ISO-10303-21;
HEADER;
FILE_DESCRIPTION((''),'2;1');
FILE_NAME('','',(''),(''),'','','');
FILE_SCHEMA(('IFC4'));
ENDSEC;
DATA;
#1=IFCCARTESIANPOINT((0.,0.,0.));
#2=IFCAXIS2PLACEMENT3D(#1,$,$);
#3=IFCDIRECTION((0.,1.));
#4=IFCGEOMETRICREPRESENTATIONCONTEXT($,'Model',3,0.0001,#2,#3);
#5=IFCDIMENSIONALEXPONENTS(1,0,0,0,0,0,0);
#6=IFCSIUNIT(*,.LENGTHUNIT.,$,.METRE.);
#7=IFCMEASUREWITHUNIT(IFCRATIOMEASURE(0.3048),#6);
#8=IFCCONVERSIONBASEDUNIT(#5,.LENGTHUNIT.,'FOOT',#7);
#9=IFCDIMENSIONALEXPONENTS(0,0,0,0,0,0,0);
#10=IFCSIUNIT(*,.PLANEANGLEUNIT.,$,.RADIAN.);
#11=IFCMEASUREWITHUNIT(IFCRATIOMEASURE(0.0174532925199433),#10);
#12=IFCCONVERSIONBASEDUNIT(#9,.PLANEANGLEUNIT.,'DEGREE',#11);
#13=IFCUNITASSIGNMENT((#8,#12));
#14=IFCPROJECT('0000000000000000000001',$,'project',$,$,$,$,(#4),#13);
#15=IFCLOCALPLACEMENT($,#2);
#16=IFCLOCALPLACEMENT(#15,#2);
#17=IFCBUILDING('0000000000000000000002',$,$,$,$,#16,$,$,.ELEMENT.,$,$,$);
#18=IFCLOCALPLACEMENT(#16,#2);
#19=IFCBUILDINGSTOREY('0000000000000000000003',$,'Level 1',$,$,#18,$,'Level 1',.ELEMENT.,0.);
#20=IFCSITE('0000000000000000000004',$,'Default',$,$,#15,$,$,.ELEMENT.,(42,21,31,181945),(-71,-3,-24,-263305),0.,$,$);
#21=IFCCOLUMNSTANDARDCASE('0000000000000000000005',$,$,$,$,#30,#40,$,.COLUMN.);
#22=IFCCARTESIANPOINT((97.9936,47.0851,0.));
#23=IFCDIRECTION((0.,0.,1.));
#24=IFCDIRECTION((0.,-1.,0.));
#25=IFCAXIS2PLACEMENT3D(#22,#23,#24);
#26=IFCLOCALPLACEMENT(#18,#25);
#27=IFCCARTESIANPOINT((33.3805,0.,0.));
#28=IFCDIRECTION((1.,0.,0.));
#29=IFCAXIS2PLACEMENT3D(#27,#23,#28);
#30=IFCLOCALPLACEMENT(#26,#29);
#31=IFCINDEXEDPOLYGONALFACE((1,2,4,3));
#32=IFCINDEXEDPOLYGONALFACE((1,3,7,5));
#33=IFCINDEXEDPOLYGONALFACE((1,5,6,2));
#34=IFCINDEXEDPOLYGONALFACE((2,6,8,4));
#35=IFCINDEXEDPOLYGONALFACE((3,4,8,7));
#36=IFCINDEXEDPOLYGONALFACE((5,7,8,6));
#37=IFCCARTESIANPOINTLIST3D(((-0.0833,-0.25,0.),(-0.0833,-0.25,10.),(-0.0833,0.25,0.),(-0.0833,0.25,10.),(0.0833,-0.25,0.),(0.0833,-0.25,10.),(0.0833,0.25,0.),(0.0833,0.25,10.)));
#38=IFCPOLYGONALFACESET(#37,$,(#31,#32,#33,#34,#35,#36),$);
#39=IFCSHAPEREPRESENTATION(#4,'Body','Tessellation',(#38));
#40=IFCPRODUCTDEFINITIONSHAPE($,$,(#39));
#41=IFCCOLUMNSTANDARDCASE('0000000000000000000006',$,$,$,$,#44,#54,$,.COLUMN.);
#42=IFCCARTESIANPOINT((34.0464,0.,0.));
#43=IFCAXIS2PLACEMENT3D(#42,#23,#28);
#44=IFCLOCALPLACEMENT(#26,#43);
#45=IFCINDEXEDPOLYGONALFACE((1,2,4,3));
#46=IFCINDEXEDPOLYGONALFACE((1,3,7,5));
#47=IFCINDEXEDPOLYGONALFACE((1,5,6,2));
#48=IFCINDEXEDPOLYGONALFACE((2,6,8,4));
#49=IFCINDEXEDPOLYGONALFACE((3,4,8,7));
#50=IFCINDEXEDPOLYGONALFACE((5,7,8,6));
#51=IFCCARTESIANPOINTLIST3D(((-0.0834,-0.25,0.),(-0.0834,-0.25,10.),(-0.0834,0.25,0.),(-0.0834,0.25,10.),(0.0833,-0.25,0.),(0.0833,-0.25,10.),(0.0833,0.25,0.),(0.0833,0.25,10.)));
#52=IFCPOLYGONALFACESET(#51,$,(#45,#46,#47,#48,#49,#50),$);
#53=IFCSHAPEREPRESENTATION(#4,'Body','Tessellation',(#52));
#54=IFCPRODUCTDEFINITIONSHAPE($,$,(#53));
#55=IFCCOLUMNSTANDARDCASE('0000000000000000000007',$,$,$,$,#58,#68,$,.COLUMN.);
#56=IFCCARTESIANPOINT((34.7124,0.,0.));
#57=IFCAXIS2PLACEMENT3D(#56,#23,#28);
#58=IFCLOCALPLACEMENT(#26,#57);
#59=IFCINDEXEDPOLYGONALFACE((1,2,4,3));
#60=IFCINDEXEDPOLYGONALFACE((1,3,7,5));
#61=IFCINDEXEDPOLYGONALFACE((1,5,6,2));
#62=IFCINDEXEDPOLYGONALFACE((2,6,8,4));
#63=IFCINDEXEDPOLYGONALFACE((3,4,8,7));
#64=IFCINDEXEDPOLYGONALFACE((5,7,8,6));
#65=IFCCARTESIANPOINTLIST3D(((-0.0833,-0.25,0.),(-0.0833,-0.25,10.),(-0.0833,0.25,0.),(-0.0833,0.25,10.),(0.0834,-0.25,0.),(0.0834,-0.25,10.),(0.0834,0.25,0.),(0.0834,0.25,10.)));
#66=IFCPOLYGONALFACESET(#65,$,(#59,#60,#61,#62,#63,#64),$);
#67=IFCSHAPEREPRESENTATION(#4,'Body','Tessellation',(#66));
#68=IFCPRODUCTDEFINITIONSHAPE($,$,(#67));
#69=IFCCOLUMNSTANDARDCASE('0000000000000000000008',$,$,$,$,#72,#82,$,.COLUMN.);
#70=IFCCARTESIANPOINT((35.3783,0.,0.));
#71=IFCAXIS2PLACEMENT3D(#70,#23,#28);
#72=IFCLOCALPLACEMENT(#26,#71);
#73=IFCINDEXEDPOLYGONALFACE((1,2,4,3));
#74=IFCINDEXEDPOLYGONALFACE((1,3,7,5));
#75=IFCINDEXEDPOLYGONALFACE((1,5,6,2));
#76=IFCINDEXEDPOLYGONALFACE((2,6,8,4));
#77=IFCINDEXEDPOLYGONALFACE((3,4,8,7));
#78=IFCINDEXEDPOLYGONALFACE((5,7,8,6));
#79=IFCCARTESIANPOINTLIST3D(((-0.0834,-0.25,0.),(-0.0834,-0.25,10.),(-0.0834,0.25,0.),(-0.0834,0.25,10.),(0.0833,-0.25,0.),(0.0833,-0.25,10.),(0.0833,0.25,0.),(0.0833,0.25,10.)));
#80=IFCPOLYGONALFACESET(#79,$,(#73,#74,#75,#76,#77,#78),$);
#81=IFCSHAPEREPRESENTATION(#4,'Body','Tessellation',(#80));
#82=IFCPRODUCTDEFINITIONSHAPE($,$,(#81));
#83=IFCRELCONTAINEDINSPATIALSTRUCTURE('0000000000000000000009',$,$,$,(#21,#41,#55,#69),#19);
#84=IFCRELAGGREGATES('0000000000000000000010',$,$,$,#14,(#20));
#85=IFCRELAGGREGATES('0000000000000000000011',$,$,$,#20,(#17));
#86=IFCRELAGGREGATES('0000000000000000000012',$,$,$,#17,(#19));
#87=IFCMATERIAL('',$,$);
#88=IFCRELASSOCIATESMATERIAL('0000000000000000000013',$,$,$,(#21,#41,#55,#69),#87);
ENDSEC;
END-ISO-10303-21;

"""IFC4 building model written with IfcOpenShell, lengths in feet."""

from ifc_helpers import new_model, entity, si_unit, converted_unit, direction, frame, origin, place, context, project, spatial, rectangle, extrude, material, element, save


model = new_model("IFC4")

# Units and contexts
model_context = context("Model", 3, precision=0.0001, world=origin(), true_north=direction((0.0, 1.0)))
ifc_project = project(units=[converted_unit("LENGTHUNIT", "FOOT", entity("IfcRatioMeasure", 0.3048), si_unit("LENGTHUNIT", "METRE"), dimensions=[1, 0, 0, 0, 0, 0, 0]), converted_unit("PLANEANGLEUNIT", "DEGREE", entity("IfcRatioMeasure", 0.0174532925199433), si_unit("PLANEANGLEUNIT", "RADIAN"), dimensions=[0, 0, 0, 0, 0, 0, 0])], contexts=[model_context])

# Site, building, storey
site_placement = place(None, origin())
site = spatial("IfcSite", under=ifc_project, at=site_placement, Name="Default", CompositionType="ELEMENT", RefLatitude=(42, 21, 31, 181945), RefLongitude=(-71, -3, -24, -263305), RefElevation=0.0)
building_placement = place(site_placement, origin())
building = spatial("IfcBuilding", under=site, at=building_placement, CompositionType="ELEMENT")
storey_placement = place(building_placement, origin())
storey = spatial("IfcBuildingStorey", under=building, at=storey_placement, Name="Level 1", LongName="Level 1", CompositionType="ELEMENT", Elevation=0.0)

# Columns
ifc_material = material(Name="")
placement = place(storey_placement, frame((97.9936, 47.0851, 0.0), z_axis=(0.0, 0.0, 1.0), x_axis=(0.0, -1.0, 0.0)))
for number, where, z_axis, x_axis in (
    (1, (33.3805, 0.0, 0.0), (0.0, 0.0, 1.0), (1.0, 0.0, 0.0)),
    (2, (34.0464, 0.0, 0.0), (0.0, 0.0, 1.0), (1.0, 0.0, 0.0)),
    (3, (34.7124, 0.0, 0.0), (0.0, 0.0, 1.0), (1.0, 0.0, 0.0)),
    (4, (35.3783, 0.0, 0.0), (0.0, 0.0, 1.0), (1.0, 0.0, 0.0)),
):
    element("IfcColumnStandardCase", number, at=place(placement, frame(where, z_axis=z_axis, x_axis=x_axis)), inside=storey, material=ifc_material, PredefinedType="COLUMN", context=model_context, shape_type="SweptSolid", body=[
        extrude(rectangle(XDim=0.1667, YDim=0.5), origin(), (0.0, 0.0, 1.0), 10.0),
    ])

save(model, "model.ifc")
